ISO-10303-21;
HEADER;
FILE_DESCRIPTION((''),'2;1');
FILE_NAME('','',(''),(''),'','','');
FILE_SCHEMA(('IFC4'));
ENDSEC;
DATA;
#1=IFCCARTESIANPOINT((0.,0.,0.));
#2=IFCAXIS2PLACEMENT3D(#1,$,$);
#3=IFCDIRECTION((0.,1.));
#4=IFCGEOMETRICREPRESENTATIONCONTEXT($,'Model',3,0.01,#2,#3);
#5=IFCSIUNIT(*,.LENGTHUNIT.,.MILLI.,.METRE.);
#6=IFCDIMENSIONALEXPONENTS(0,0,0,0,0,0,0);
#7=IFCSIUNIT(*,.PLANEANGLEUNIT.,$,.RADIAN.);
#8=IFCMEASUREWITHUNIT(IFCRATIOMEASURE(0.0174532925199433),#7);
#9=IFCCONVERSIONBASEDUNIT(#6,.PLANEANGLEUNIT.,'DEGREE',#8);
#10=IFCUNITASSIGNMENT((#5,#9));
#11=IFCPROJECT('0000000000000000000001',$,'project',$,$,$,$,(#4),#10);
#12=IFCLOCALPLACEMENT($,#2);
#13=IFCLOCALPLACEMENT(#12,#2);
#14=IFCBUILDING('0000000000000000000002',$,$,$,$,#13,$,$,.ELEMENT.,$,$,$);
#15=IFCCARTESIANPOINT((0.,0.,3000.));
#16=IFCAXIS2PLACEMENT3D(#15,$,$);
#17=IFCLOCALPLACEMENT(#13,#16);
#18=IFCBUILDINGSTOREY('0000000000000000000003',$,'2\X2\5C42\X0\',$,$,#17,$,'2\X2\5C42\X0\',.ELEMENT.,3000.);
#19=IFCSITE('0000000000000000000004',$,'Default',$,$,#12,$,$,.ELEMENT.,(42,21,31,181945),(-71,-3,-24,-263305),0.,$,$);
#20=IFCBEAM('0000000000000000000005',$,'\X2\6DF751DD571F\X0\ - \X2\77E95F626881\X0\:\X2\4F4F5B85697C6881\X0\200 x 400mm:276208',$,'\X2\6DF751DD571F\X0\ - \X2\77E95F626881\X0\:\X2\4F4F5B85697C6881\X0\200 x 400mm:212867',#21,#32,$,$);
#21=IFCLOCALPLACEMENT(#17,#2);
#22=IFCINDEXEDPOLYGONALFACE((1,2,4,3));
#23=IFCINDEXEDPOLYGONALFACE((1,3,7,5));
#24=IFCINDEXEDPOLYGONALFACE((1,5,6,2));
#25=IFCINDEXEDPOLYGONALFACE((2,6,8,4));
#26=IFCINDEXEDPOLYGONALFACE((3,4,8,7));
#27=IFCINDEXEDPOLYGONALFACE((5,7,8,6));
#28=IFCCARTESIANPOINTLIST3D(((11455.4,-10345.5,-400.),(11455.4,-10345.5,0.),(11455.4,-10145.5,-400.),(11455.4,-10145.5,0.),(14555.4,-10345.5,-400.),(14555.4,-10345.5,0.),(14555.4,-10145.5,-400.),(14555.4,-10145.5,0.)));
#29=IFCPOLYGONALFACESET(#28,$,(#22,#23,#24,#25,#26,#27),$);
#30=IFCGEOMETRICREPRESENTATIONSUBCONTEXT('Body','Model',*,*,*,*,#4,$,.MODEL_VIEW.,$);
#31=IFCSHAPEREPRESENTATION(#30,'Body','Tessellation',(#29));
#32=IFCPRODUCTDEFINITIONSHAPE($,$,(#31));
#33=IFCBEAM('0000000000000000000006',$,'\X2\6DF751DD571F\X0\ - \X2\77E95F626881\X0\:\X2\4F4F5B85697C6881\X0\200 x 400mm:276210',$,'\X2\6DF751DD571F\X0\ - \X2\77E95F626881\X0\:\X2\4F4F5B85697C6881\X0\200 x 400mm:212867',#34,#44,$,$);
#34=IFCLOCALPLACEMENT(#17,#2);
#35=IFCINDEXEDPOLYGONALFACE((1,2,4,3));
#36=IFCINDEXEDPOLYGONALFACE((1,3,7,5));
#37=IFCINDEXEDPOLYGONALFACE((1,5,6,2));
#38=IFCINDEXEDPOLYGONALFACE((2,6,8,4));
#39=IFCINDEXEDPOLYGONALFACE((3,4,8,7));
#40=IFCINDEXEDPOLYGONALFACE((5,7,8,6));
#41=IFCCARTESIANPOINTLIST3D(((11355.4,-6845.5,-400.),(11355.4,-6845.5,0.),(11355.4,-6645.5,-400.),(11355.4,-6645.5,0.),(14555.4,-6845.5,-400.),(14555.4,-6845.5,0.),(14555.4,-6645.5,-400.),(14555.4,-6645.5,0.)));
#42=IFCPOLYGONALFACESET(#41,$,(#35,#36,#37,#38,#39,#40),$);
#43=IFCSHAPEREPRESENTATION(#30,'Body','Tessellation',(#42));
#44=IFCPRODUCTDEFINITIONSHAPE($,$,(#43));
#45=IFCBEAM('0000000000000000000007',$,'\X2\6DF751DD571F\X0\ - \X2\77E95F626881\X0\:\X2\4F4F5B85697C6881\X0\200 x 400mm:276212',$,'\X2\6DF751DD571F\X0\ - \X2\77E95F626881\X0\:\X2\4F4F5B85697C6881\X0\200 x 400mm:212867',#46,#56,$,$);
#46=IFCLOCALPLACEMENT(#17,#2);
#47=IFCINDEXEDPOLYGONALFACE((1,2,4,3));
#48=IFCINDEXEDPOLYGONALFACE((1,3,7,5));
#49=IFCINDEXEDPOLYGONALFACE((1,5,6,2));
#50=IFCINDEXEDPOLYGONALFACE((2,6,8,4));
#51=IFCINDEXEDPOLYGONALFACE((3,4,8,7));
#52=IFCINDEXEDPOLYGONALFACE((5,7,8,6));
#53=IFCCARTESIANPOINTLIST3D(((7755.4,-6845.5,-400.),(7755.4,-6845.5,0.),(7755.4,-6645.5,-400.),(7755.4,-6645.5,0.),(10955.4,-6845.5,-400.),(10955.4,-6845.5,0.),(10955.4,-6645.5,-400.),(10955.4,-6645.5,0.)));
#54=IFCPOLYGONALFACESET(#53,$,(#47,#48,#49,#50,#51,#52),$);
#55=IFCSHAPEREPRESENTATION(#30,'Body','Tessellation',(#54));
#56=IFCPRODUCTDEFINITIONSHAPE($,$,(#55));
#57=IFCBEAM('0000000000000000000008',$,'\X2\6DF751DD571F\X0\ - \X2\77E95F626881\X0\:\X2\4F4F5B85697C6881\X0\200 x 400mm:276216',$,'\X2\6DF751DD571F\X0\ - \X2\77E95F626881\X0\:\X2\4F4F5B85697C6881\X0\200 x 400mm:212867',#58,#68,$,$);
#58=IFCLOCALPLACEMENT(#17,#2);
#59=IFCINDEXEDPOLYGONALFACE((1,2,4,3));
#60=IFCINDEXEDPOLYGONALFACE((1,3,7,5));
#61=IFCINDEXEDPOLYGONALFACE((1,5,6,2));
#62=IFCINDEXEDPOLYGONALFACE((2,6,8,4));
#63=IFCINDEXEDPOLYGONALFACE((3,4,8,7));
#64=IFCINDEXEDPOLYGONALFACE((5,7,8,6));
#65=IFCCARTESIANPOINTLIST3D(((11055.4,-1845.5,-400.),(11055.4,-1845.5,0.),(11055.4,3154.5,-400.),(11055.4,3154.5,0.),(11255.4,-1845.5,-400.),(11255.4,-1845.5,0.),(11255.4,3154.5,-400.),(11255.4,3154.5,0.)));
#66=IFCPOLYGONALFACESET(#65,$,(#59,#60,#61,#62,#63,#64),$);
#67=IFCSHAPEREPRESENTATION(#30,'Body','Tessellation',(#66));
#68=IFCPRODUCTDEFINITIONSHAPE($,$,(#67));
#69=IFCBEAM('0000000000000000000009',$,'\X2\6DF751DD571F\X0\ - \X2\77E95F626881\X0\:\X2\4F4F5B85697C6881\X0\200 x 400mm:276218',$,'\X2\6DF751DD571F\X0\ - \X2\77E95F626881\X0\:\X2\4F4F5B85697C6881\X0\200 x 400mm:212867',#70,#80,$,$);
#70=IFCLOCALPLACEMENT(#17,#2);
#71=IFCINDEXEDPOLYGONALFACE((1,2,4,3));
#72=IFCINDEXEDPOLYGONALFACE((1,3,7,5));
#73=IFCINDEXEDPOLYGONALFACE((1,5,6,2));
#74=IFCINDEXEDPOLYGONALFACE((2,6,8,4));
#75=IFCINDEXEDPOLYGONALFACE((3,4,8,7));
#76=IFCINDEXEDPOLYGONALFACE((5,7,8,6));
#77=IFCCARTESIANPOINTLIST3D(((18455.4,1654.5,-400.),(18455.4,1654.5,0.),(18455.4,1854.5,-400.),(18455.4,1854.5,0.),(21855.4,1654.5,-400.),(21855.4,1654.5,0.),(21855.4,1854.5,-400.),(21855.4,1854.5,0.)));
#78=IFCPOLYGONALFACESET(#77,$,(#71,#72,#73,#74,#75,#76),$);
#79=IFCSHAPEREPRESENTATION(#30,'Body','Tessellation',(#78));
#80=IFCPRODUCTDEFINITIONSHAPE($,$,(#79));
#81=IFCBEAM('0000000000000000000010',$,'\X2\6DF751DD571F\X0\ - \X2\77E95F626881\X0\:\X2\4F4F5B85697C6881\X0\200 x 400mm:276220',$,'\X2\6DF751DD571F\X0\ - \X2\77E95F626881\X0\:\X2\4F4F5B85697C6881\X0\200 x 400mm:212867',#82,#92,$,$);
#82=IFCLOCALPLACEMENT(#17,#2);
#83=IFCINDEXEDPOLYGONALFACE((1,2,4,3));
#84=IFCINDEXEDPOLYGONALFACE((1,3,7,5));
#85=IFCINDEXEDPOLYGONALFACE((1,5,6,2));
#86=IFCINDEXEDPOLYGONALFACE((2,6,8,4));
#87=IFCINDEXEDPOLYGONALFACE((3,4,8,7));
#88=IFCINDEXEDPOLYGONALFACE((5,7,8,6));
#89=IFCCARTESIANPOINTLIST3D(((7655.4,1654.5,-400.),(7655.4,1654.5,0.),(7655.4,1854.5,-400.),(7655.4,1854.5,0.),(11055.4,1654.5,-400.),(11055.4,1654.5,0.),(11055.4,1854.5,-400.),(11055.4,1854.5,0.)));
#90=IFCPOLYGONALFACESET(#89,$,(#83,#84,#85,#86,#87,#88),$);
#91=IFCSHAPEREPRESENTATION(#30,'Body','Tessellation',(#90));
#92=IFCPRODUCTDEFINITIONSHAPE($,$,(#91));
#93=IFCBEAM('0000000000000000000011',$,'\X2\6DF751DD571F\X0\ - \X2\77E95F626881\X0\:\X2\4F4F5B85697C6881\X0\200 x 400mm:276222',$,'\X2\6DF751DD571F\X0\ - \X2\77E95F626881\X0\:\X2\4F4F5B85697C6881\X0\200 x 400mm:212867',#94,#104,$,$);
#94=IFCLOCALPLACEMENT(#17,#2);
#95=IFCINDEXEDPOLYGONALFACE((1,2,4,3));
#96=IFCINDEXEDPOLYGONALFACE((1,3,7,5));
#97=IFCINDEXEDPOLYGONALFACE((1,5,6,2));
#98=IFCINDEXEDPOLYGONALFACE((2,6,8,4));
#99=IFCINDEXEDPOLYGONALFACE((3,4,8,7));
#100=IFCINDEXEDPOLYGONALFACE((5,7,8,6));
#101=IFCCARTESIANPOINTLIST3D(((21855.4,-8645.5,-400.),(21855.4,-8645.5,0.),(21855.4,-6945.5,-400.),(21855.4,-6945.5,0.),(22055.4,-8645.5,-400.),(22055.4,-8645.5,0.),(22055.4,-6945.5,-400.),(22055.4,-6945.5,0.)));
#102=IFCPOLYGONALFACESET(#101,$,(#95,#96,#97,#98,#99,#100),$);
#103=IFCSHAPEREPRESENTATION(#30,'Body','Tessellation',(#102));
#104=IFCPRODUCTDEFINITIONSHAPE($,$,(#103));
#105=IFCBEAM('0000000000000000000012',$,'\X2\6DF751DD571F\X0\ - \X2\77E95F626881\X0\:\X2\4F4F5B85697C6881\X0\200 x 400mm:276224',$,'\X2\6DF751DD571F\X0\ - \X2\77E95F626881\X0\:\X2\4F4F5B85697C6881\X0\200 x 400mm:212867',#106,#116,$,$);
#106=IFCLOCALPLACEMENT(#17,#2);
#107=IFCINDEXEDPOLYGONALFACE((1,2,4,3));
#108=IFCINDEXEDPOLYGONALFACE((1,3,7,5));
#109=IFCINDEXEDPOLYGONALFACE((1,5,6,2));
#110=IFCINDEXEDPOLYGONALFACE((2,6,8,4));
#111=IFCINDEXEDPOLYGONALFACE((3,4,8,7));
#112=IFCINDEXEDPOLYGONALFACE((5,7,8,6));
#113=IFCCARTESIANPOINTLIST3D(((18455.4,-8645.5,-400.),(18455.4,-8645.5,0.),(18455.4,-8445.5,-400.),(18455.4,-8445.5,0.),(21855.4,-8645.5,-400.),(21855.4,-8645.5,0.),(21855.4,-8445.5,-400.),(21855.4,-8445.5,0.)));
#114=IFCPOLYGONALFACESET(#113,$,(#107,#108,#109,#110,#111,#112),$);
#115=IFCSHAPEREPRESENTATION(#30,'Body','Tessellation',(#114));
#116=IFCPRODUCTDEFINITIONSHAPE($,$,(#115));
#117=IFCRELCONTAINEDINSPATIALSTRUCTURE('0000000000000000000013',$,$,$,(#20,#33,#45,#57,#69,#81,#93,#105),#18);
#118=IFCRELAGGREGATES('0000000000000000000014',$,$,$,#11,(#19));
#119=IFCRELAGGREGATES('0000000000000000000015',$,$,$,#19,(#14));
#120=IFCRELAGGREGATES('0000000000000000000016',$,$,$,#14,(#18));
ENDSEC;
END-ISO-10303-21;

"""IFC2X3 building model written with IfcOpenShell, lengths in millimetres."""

from ifc_helpers import new_model, entity, si_unit, converted_unit, direction, frame, frame_2d, origin, place, context, subcontext, project, spatial, rectangle, extrude, element, save


model = new_model("IFC2X3")

# Units and contexts
model_context = context("Model", 3, precision=0.01, world=origin(), true_north=direction((0.0, 1.0)))
body_context = subcontext(model_context, "Body", "Model", "MODEL_VIEW")
ifc_project = project(units=[si_unit("LENGTHUNIT", "METRE", prefix="MILLI"), converted_unit("PLANEANGLEUNIT", "DEGREE", entity("IfcRatioMeasure", 0.0174532925199433), si_unit("PLANEANGLEUNIT", "RADIAN"), dimensions=[0, 0, 0, 0, 0, 0, 0])], contexts=[model_context])

# Site, building, storey
site_placement = place(None, origin())
site = spatial("IfcSite", under=ifc_project, at=site_placement, Name="Default", CompositionType="ELEMENT", RefLatitude=(42, 21, 31, 181945), RefLongitude=(-71, -3, -24, -263305), RefElevation=0.0)
building_placement = place(site_placement, origin())
building = spatial("IfcBuilding", under=site, at=building_placement, CompositionType="ELEMENT")
storey_placement = place(building_placement, frame((0.0, 0.0, 3000.0)))
storey = spatial("IfcBuildingStorey", under=building, at=storey_placement, Name="2层", LongName="2层", CompositionType="ELEMENT", Elevation=3000.0)

# Beams
beam_1_placement = place(storey_placement, frame((11455.4, -10245.5, 0.0)))
element("IfcBeam", 1, at=beam_1_placement, inside=storey, Name="混凝土 - 矩形梁:住宅楼梁200 x 400mm:276208", ObjectType="混凝土 - 矩形梁:住宅楼梁200 x 400mm:212867", context=body_context, shape_type="SweptSolid", body=[
    extrude(rectangle(XDim=400.0, YDim=200.0, at=frame_2d((0.0, 0.0), x_axis=(1.0, 0.0))), frame((0.0, 0.0, -200.0), z_axis=(1.0, 0.0, 0.0), x_axis=(0.0, 0.0, -1.0)), (0.0, 0.0, 1.0), 3100.0),
])
beam_2_placement = place(storey_placement, frame((11155.4, -6745.5, 0.0)))
element("IfcBeam", 2, at=beam_2_placement, inside=storey, Name="混凝土 - 矩形梁:住宅楼梁200 x 400mm:276210", ObjectType="混凝土 - 矩形梁:住宅楼梁200 x 400mm:212867", context=body_context, shape_type="SweptSolid", body=[
    extrude(rectangle(XDim=400.0, YDim=200.0, at=frame_2d((0.0, 0.0), x_axis=(1.0, 0.0))), frame((200.0, 0.0, -200.0), z_axis=(1.0, 0.0, 0.0), x_axis=(0.0, 0.0, -1.0)), (0.0, 0.0, 1.0), 3200.0),
])
beam_3_placement = place(storey_placement, frame((11155.4, -6745.5, 0.0), z_axis=(0.0, 0.0, 1.0), x_axis=(-1.0, 0.0, 0.0)))
element("IfcBeam", 3, at=beam_3_placement, inside=storey, Name="混凝土 - 矩形梁:住宅楼梁200 x 400mm:276212", ObjectType="混凝土 - 矩形梁:住宅楼梁200 x 400mm:212867", context=body_context, shape_type="SweptSolid", body=[
    extrude(rectangle(XDim=400.0, YDim=200.0, at=frame_2d((0.0, 0.0), x_axis=(1.0, 0.0))), frame((200.0, 0.0, -200.0), z_axis=(1.0, 0.0, 0.0), x_axis=(0.0, 0.0, -1.0)), (0.0, 0.0, 1.0), 3200.0),
])
beam_4_placement = place(storey_placement, frame((11155.4, 3254.5, 0.0), z_axis=(0.0, 0.0, 1.0), x_axis=(0.0, -1.0, 0.0)))
element("IfcBeam", 4, at=beam_4_placement, inside=storey, Name="混凝土 - 矩形梁:住宅楼梁200 x 400mm:276216", ObjectType="混凝土 - 矩形梁:住宅楼梁200 x 400mm:212867", context=body_context, shape_type="SweptSolid", body=[
    extrude(rectangle(XDim=400.0, YDim=200.0, at=frame_2d((0.0, 0.0), x_axis=(1.0, 0.0))), frame((100.0, 0.0, -200.0), z_axis=(1.0, 0.0, 0.0), x_axis=(0.0, 0.0, -1.0)), (0.0, 0.0, 1.0), 5000.0),
])
beam_5_placement = place(storey_placement, frame((21955.4, 1754.5, 0.0), z_axis=(0.0, 0.0, 1.0), x_axis=(-1.0, 0.0, 0.0)))
element("IfcBeam", 5, at=beam_5_placement, inside=storey, Name="混凝土 - 矩形梁:住宅楼梁200 x 400mm:276218", ObjectType="混凝土 - 矩形梁:住宅楼梁200 x 400mm:212867", context=body_context, shape_type="SweptSolid", body=[
    extrude(rectangle(XDim=400.0, YDim=200.0, at=frame_2d((0.0, 0.0), x_axis=(1.0, 0.0))), frame((100.0, 0.0, -200.0), z_axis=(1.0, 0.0, 0.0), x_axis=(0.0, 0.0, -1.0)), (0.0, 0.0, 1.0), 3400.0),
])
beam_6_placement = place(storey_placement, frame((7555.4, 1754.5, 0.0)))
element("IfcBeam", 6, at=beam_6_placement, inside=storey, Name="混凝土 - 矩形梁:住宅楼梁200 x 400mm:276220", ObjectType="混凝土 - 矩形梁:住宅楼梁200 x 400mm:212867", context=body_context, shape_type="SweptSolid", body=[
    extrude(rectangle(XDim=400.0, YDim=200.0, at=frame_2d((0.0, 0.0), x_axis=(1.0, 0.0))), frame((100.0, 0.0, -200.0), z_axis=(1.0, 0.0, 0.0), x_axis=(0.0, 0.0, -1.0)), (0.0, 0.0, 1.0), 3400.0),
])
beam_7_placement = place(storey_placement, frame((21955.4, -6745.5, 0.0), z_axis=(0.0, 0.0, 1.0), x_axis=(0.0, -1.0, 0.0)))
element("IfcBeam", 7, at=beam_7_placement, inside=storey, Name="混凝土 - 矩形梁:住宅楼梁200 x 400mm:276222", ObjectType="混凝土 - 矩形梁:住宅楼梁200 x 400mm:212867", context=body_context, shape_type="SweptSolid", body=[
    extrude(rectangle(XDim=400.0, YDim=200.0, at=frame_2d((0.0, 0.0), x_axis=(1.0, 0.0))), frame((200.0, 0.0, -200.0), z_axis=(1.0, 0.0, 0.0), x_axis=(0.0, 0.0, -1.0)), (0.0, 0.0, 1.0), 1700.0),
])
beam_8_placement = place(storey_placement, frame((21955.4, -8545.5, 0.0), z_axis=(0.0, 0.0, 1.0), x_axis=(-1.0, 0.0, 0.0)))
element("IfcBeam", 8, at=beam_8_placement, inside=storey, Name="混凝土 - 矩形梁:住宅楼梁200 x 400mm:276224", ObjectType="混凝土 - 矩形梁:住宅楼梁200 x 400mm:212867", context=body_context, shape_type="SweptSolid", body=[
    extrude(rectangle(XDim=400.0, YDim=200.0, at=frame_2d((0.0, 0.0), x_axis=(1.0, 0.0))), frame((100.0, 0.0, -200.0), z_axis=(1.0, 0.0, 0.0), x_axis=(0.0, 0.0, -1.0)), (0.0, 0.0, 1.0), 3400.0),
])

save(model, "model.ifc")
